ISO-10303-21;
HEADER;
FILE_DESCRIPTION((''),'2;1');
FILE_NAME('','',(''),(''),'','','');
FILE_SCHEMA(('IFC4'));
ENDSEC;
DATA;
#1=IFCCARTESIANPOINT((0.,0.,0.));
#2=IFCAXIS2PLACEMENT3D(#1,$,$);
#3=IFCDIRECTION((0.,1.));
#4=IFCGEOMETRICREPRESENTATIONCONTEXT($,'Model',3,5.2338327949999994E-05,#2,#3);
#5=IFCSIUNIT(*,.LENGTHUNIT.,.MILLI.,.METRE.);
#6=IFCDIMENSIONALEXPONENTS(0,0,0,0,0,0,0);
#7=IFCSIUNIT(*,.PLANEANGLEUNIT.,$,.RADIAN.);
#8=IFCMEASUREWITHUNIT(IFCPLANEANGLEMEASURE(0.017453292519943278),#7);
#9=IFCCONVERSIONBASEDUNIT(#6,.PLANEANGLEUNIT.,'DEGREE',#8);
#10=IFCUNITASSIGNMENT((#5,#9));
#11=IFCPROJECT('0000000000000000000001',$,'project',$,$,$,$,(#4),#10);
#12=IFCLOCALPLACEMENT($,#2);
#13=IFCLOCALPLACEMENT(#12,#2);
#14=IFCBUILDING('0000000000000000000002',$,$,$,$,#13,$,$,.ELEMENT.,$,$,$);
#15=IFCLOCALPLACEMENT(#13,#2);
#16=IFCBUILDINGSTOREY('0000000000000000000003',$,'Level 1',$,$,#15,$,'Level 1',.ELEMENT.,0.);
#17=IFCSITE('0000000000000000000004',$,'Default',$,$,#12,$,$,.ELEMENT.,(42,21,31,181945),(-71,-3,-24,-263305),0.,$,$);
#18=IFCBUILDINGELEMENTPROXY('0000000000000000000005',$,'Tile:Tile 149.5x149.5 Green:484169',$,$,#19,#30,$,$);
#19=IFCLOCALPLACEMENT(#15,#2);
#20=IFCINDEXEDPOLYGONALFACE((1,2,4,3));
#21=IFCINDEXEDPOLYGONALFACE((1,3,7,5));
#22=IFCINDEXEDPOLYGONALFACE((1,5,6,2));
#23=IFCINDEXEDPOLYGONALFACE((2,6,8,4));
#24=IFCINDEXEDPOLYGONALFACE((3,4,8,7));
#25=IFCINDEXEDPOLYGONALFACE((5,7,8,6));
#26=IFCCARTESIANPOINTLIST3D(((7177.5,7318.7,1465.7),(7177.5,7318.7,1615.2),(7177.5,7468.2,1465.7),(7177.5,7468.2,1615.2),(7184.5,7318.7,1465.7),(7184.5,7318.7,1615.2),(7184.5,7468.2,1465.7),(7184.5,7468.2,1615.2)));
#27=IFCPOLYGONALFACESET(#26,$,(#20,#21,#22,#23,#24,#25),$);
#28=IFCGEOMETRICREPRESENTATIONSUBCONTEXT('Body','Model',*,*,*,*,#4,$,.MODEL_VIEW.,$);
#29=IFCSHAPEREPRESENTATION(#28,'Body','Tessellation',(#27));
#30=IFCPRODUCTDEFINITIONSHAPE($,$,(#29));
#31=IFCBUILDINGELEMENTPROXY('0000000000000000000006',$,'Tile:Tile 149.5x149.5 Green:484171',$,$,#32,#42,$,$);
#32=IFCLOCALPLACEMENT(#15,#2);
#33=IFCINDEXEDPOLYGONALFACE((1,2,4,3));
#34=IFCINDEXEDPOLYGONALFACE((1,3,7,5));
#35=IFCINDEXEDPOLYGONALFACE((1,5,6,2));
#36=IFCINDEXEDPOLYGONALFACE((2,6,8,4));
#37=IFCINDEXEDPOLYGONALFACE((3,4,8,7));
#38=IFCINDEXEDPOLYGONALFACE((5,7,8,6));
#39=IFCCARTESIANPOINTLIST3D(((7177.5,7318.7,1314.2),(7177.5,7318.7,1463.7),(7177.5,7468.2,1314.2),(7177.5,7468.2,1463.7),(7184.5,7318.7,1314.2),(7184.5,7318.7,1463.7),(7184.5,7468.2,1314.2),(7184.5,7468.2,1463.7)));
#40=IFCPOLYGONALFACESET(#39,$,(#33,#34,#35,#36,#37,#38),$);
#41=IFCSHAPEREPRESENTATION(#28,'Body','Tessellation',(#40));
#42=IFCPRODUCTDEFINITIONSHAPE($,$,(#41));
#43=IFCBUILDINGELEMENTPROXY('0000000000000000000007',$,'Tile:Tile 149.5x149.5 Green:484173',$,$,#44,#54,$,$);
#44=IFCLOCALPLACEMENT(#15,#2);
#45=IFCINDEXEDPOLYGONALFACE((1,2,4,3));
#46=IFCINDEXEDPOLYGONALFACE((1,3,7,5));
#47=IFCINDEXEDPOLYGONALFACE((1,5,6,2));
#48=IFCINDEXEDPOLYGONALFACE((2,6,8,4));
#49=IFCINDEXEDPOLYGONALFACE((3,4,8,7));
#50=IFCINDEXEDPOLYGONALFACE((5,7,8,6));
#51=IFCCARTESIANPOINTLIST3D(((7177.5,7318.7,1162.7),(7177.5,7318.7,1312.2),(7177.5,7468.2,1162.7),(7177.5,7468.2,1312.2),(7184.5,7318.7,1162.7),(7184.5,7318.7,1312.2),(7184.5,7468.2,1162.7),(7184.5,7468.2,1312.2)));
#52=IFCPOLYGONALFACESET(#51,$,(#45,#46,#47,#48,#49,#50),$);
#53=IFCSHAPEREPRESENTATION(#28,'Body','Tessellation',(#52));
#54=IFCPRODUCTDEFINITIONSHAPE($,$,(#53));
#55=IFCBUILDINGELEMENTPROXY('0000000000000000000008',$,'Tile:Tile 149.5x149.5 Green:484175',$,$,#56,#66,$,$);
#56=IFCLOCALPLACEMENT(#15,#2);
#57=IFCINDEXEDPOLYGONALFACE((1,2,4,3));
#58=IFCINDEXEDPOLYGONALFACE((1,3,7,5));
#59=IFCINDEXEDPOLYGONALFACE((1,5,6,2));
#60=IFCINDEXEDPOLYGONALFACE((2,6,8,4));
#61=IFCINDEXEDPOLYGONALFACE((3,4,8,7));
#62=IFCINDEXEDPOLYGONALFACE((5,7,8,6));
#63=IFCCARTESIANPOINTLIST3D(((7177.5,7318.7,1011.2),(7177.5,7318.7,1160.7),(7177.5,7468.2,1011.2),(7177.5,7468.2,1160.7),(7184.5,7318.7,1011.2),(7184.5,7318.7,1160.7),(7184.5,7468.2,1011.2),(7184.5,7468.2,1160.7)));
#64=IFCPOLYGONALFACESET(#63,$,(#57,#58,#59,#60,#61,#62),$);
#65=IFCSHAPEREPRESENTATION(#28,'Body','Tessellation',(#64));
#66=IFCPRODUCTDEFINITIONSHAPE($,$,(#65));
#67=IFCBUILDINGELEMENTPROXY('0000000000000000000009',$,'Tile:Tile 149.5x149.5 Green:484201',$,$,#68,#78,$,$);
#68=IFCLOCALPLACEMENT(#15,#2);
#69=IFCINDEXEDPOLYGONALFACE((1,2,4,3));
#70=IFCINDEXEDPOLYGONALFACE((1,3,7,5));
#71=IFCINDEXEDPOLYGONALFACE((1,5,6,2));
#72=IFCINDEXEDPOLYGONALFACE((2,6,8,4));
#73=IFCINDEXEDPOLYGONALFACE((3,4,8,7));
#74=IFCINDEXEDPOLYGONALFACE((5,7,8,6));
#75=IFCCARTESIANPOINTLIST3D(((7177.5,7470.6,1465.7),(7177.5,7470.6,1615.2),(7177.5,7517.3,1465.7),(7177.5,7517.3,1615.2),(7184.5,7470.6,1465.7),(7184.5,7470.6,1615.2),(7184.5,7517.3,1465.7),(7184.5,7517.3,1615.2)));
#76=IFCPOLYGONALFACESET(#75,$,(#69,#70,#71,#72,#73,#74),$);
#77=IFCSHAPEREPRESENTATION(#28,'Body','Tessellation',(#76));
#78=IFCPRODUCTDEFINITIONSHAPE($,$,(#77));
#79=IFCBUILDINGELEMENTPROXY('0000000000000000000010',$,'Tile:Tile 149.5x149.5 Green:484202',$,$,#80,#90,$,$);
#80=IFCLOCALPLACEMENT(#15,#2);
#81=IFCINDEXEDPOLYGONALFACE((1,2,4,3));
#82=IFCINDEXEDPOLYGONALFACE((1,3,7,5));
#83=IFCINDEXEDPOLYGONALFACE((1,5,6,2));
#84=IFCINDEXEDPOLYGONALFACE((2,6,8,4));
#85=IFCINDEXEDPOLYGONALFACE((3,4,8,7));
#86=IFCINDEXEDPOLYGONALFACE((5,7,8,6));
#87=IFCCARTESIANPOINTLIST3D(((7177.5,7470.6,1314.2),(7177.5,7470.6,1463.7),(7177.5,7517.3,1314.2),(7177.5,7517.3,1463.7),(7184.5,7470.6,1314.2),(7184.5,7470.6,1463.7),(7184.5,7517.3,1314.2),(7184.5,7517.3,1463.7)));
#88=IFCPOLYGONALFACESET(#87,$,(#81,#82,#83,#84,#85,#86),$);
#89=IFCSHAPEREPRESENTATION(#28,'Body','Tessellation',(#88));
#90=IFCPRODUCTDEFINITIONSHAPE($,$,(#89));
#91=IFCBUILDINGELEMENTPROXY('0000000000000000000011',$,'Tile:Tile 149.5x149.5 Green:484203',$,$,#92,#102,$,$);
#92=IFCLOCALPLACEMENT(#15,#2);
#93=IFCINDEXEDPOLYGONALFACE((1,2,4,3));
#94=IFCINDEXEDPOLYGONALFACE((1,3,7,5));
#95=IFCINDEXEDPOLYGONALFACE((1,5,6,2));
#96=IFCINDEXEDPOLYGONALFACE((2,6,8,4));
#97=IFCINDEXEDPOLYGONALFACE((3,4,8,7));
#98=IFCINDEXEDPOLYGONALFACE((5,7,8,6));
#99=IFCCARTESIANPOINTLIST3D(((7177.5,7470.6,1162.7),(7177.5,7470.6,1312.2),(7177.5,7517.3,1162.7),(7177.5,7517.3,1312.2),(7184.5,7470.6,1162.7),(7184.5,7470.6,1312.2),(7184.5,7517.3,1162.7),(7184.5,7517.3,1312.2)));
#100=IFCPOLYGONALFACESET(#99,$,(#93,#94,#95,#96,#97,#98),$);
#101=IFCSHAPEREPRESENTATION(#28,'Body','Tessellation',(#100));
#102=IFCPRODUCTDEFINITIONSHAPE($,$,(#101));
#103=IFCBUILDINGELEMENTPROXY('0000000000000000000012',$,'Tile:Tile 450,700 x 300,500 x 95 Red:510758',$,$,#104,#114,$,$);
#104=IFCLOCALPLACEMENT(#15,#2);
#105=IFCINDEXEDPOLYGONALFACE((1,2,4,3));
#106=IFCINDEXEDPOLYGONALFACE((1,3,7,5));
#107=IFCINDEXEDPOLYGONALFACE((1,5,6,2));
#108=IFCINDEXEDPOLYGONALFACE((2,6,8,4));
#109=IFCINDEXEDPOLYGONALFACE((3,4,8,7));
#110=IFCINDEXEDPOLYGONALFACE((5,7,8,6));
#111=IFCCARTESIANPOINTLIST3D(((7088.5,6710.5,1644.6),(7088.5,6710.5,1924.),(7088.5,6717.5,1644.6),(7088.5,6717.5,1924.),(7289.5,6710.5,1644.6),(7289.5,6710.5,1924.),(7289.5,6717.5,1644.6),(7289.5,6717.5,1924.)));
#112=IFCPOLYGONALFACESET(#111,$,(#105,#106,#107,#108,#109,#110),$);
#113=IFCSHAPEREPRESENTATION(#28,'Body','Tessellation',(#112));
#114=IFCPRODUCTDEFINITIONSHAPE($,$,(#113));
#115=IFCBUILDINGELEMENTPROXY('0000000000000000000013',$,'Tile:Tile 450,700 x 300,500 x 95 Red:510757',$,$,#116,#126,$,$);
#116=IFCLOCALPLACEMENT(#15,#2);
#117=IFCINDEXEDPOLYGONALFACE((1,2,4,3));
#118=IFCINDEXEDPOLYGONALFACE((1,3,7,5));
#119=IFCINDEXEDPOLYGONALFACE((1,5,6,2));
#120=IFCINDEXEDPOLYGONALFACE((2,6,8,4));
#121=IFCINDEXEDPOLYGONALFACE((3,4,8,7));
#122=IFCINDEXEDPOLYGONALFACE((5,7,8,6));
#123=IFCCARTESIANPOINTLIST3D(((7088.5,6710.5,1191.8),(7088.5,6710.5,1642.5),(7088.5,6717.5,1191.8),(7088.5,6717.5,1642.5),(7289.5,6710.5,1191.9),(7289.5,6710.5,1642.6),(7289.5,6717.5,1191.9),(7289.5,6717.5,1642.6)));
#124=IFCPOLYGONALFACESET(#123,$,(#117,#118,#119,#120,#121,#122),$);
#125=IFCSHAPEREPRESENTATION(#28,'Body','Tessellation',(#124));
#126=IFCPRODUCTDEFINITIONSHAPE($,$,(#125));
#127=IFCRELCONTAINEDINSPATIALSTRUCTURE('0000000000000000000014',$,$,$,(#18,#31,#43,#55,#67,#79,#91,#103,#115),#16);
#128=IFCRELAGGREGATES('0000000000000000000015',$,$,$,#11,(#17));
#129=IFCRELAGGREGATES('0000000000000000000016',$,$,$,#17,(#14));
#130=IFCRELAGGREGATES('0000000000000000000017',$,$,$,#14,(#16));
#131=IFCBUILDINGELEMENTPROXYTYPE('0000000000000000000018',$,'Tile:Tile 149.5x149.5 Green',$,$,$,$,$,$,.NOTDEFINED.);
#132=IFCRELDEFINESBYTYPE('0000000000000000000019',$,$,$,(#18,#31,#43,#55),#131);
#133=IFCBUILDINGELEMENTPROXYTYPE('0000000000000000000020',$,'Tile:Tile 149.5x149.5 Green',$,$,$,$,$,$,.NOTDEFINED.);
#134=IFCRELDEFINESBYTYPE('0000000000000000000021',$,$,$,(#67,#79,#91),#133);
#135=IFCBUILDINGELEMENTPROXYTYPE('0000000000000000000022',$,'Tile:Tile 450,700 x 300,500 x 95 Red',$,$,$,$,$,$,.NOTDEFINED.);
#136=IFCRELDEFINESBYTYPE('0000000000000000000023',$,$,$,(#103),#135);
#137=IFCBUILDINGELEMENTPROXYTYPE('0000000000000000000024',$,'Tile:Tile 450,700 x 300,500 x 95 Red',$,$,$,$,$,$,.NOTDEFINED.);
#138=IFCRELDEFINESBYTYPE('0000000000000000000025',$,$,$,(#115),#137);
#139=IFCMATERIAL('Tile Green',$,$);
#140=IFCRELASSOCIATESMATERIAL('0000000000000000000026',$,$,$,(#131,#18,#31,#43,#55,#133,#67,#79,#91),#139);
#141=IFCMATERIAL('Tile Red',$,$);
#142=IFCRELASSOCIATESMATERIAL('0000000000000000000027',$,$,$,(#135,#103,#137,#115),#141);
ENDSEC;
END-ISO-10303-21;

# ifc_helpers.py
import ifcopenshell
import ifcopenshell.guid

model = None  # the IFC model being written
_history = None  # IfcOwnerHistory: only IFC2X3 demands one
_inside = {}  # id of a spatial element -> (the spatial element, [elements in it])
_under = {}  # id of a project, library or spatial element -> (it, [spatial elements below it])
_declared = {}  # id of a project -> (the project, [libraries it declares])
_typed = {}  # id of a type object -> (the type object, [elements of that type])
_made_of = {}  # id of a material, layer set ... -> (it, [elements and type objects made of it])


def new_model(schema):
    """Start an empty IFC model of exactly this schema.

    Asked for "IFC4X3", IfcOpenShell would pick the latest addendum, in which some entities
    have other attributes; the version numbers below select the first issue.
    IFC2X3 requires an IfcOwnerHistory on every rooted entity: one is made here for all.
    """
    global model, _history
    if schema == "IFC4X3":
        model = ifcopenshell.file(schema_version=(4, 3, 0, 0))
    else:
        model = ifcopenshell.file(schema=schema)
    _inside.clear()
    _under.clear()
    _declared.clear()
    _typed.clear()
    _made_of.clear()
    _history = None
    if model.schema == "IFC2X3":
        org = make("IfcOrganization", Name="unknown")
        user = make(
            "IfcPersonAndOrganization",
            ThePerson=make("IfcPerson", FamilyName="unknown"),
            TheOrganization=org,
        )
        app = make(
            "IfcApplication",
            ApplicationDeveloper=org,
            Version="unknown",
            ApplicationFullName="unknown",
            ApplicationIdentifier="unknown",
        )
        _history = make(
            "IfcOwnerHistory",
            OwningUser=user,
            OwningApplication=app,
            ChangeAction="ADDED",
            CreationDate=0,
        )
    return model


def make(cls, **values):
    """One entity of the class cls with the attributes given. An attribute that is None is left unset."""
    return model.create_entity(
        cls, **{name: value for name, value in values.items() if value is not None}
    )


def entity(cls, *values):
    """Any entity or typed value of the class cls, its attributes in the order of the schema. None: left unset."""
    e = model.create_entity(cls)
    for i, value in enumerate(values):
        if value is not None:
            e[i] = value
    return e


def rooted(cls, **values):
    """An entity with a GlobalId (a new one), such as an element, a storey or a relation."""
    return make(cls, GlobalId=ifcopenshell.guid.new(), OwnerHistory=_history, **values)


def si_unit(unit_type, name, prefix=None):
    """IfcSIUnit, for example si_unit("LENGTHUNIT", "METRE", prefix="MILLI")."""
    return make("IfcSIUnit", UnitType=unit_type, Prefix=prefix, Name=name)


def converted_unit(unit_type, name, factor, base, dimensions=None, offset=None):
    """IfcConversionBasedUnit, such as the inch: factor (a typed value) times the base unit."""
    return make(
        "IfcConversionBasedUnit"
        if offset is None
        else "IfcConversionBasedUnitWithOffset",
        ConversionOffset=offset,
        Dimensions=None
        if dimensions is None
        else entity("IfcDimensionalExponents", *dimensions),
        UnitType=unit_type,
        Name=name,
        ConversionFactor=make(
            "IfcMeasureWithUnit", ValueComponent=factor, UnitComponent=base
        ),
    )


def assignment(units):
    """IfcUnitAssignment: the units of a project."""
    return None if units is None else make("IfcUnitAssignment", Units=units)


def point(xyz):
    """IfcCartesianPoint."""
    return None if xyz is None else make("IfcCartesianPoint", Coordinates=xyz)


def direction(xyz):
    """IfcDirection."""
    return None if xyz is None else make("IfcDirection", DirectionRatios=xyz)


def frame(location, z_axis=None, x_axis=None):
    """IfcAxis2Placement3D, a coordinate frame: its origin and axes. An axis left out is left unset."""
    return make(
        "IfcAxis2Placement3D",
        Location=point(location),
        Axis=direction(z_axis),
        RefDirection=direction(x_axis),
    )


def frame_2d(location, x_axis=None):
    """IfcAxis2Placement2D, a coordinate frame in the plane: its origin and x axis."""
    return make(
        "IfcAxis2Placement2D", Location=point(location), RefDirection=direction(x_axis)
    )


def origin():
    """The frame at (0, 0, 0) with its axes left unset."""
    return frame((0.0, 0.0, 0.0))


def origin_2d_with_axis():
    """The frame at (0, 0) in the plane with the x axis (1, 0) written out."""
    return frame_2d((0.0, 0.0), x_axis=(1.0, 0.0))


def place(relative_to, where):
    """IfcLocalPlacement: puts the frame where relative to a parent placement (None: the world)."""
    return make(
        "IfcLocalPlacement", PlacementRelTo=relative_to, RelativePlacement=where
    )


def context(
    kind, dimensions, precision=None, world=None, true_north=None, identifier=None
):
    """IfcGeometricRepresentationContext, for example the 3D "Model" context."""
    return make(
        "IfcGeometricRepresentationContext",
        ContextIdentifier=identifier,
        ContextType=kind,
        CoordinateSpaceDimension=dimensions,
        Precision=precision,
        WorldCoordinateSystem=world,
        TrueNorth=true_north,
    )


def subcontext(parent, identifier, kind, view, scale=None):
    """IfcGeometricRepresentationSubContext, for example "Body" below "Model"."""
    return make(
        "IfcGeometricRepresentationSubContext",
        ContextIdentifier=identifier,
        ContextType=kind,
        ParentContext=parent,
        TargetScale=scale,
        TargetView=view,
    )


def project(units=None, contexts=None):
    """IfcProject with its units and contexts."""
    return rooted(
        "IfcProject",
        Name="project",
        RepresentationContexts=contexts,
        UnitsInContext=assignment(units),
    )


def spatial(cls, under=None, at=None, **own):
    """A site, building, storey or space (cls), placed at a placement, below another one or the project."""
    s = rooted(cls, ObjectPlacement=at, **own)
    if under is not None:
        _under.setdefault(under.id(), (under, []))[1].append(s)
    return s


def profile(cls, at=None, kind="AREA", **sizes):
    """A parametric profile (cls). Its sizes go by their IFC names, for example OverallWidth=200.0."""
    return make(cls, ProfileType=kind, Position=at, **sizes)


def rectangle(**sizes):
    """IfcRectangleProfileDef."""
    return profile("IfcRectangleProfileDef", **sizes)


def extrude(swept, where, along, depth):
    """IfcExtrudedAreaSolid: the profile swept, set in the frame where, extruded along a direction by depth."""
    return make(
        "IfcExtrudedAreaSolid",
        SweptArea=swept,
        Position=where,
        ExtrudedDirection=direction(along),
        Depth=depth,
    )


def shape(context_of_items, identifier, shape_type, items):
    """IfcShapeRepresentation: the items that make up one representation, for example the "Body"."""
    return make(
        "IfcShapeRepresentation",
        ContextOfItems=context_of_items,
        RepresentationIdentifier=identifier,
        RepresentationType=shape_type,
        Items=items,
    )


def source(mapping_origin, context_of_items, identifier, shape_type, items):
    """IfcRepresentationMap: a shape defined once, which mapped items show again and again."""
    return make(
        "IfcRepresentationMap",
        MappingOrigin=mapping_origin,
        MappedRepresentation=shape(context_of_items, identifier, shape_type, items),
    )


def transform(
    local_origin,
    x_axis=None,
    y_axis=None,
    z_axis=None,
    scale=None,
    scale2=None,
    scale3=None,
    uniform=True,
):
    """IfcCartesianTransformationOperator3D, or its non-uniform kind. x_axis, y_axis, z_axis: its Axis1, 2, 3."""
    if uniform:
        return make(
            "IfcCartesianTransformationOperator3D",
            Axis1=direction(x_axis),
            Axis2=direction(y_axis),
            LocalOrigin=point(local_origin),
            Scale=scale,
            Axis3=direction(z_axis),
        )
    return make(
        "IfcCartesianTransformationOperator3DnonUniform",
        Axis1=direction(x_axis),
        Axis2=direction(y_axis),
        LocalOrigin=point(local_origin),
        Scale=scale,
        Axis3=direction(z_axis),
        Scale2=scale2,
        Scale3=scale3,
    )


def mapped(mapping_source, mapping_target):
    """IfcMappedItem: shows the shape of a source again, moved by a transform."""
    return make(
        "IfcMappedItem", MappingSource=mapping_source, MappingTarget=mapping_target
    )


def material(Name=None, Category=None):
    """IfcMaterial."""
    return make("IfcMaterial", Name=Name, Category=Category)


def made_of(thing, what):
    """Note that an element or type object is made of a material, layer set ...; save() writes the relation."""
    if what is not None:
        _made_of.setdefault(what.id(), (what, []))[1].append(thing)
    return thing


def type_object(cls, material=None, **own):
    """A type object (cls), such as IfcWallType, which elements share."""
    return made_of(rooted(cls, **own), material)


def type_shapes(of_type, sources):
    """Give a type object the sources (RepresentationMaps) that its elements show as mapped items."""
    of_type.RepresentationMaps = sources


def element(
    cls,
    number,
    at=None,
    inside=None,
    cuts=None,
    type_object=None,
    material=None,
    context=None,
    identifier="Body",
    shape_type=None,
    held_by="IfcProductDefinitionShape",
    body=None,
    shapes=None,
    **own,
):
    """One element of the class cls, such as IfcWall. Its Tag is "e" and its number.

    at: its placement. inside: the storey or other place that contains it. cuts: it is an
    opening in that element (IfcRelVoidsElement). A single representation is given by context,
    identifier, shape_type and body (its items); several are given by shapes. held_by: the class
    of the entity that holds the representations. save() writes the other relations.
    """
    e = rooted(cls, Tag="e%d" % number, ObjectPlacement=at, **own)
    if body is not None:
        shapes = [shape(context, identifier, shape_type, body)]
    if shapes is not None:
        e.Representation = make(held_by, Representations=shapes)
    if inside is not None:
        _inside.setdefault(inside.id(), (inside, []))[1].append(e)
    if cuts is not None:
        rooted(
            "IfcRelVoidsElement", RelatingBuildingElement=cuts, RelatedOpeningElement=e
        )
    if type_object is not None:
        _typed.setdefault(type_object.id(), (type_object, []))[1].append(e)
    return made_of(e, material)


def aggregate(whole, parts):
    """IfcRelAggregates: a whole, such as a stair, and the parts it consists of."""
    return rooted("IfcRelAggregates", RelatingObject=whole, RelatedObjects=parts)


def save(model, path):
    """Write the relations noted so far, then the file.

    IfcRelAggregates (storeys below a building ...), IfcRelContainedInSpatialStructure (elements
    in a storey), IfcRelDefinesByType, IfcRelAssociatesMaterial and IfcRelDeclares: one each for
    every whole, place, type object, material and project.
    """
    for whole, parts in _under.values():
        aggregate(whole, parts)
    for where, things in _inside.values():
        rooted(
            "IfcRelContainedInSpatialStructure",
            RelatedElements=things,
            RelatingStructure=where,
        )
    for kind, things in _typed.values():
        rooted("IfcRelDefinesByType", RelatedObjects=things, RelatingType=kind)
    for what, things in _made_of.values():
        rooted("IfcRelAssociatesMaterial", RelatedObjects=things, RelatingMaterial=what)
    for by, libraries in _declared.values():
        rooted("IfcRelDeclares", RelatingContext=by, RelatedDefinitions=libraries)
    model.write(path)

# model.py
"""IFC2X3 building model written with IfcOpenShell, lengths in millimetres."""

from ifc_helpers import new_model, entity, si_unit, converted_unit, direction, frame, frame_2d, origin, origin_2d_with_axis, place, context, subcontext, project, spatial, rectangle, extrude, source, transform, mapped, material, type_object, type_shapes, element, save


model = new_model("IFC2X3")

# Units and contexts
model_context = context("Model", 3, precision=5.2338327949999994e-05, world=origin(), true_north=direction((0.0, 1.0)))
body_context = subcontext(model_context, "Body", "Model", "MODEL_VIEW")
ifc_project = project(units=[si_unit("LENGTHUNIT", "METRE", prefix="MILLI"), converted_unit("PLANEANGLEUNIT", "DEGREE", entity("IfcPlaneAngleMeasure", 0.017453292519943278), si_unit("PLANEANGLEUNIT", "RADIAN"), dimensions=[0, 0, 0, 0, 0, 0, 0])], contexts=[model_context])

# Site, building, storey
site_placement = place(None, origin())
site = spatial("IfcSite", under=ifc_project, at=site_placement, Name="Default", CompositionType="ELEMENT", RefLatitude=(42, 21, 31, 181945), RefLongitude=(-71, -3, -24, -263305), RefElevation=0.0)
building_placement = place(site_placement, origin())
building = spatial("IfcBuilding", under=site, at=building_placement, CompositionType="ELEMENT")
storey_placement = place(building_placement, origin())
storey = spatial("IfcBuildingStorey", under=building, at=storey_placement, Name="Level 1", LongName="Level 1", CompositionType="ELEMENT", Elevation=0.0)

# Building element proxies
ifc_material_1 = material(Name="Tile Green")
building_element_proxy_type_1 = type_object("IfcBuildingElementProxyType", Name="Tile:Tile 149.5x149.5 Green", PredefinedType="NOTDEFINED", material=ifc_material_1)
shared_shape_1 = source(origin(), body_context, "Body", "SweptSolid", [
    extrude(rectangle(XDim=149.5, YDim=149.5, at=origin_2d_with_axis()), frame((-74.7, -74.8, 0.0), z_axis=(0.0, 0.0, 1.0), x_axis=(0.0, -1.0, 0.0)), (0.0, 0.0, 1.0), 7.0),
])
type_shapes(building_element_proxy_type_1, [shared_shape_1])
for number, where, z_axis, x_axis, name in (
    (1, (7184.5, 7468.2, 1615.2), (-1.0, 0.0, 0.0), (0.0, 0.0, 1.0), "Tile:Tile 149.5x149.5 Green:484169"),
    (2, (7184.5, 7468.2, 1463.7), (-1.0, 0.0, 0.0), (0.0, 0.0, 1.0), "Tile:Tile 149.5x149.5 Green:484171"),
    (3, (7184.5, 7468.2, 1312.2), (-1.0, 0.0, 0.0), (0.0, 0.0, 1.0), "Tile:Tile 149.5x149.5 Green:484173"),
    (4, (7184.5, 7468.2, 1160.7), (-1.0, 0.0, 0.0), (0.0, 0.0, 1.0), "Tile:Tile 149.5x149.5 Green:484175"),
):
    element("IfcBuildingElementProxy", number, at=place(storey_placement, frame(where, z_axis=z_axis, x_axis=x_axis)), inside=storey, type_object=building_element_proxy_type_1, material=ifc_material_1, Name=name, context=body_context, shape_type="MappedRepresentation", body=[
        mapped(shared_shape_1, transform((0.0, 0.0, 0.0), scale=1.0)),
    ])
building_element_proxy_type_2 = type_object("IfcBuildingElementProxyType", Name="Tile:Tile 149.5x149.5 Green", PredefinedType="NOTDEFINED", material=ifc_material_1)
shared_shape_2 = source(origin(), body_context, "Body", "SweptSolid", [
    extrude(rectangle(XDim=46.7, YDim=149.5, at=origin_2d_with_axis()), frame((-23.3, -74.8, 0.0), z_axis=(0.0, 0.0, 1.0), x_axis=(-1.0, 0.0, 0.0)), (0.0, 0.0, 1.0), 7.0),
])
type_shapes(building_element_proxy_type_2, [shared_shape_2])
for number, where, z_axis, x_axis, name in (
    (5, (7184.5, 7517.3, 1465.7), (-1.0, 0.0, 0.0), (0.0, 1.0, 0.0), "Tile:Tile 149.5x149.5 Green:484201"),
    (6, (7184.5, 7517.3, 1314.2), (-1.0, 0.0, 0.0), (0.0, 1.0, 0.0), "Tile:Tile 149.5x149.5 Green:484202"),
    (7, (7184.5, 7517.3, 1162.7), (-1.0, 0.0, 0.0), (0.0, 1.0, 0.0), "Tile:Tile 149.5x149.5 Green:484203"),
):
    element("IfcBuildingElementProxy", number, at=place(storey_placement, frame(where, z_axis=z_axis, x_axis=x_axis)), inside=storey, type_object=building_element_proxy_type_2, material=ifc_material_1, Name=name, context=body_context, shape_type="MappedRepresentation", body=[
        mapped(shared_shape_2, transform((0.0, 0.0, 0.0), scale=1.0)),
    ])
ifc_material_2 = material(Name="Tile Red")
building_element_proxy_type_3 = type_object("IfcBuildingElementProxyType", Name="Tile:Tile 450,700 x 300,500 x 95 Red", PredefinedType="NOTDEFINED", material=ifc_material_2)
shared_shape_3 = source(origin(), body_context, "Body", "SweptSolid", [
    extrude(rectangle(XDim=201.0, YDim=279.5, at=frame_2d((0.0, 0.0), x_axis=(1.0, 0.0))), frame((-100.5, -139.7, 0.0), z_axis=(0.0, 0.0, 1.0), x_axis=(-1.0, 0.0, 0.0)), (0.0, 0.0, 1.0), 7.0),
])
type_shapes(building_element_proxy_type_3, [shared_shape_3])
proxy_1_placement = place(storey_placement, frame((7088.5, 6717.5, 1644.6), z_axis=(0.0, -1.0, 0.0), x_axis=(-1.0, 0.0, 0.0)))
element("IfcBuildingElementProxy", 8, at=proxy_1_placement, inside=storey, type_object=building_element_proxy_type_3, material=ifc_material_2, Name="Tile:Tile 450,700 x 300,500 x 95 Red:510758", context=body_context, shape_type="MappedRepresentation", body=[
    mapped(shared_shape_3, transform((0.0, 0.0, 0.0), scale=1.0)),
])
building_element_proxy_type_4 = type_object("IfcBuildingElementProxyType", Name="Tile:Tile 450,700 x 300,500 x 95 Red", PredefinedType="NOTDEFINED", material=ifc_material_2)
shared_shape_4 = source(origin(), body_context, "Body", "SweptSolid", [
    extrude(rectangle(XDim=201.0, YDim=450.7, at=frame_2d((0.0, 0.0), x_axis=(1.0, 0.0))), frame((-100.5, -225.4, 0.0), z_axis=(0.0, 0.0, 1.0), x_axis=(-1.0, 0.0, 0.0)), (0.0, 0.0, 1.0), 7.0),
])
type_shapes(building_element_proxy_type_4, [shared_shape_4])
proxy_2_placement = place(storey_placement, frame((7088.5, 6717.5, 1191.8), z_axis=(0.0, -1.0, 0.0), x_axis=(-1.0, 0.0, -0.000041)))
element("IfcBuildingElementProxy", 9, at=proxy_2_placement, inside=storey, type_object=building_element_proxy_type_4, material=ifc_material_2, Name="Tile:Tile 450,700 x 300,500 x 95 Red:510757", context=body_context, shape_type="MappedRepresentation", body=[
    mapped(shared_shape_4, transform((0.0, 0.0, 0.0), scale=1.0)),
])

save(model, "model.ifc")
